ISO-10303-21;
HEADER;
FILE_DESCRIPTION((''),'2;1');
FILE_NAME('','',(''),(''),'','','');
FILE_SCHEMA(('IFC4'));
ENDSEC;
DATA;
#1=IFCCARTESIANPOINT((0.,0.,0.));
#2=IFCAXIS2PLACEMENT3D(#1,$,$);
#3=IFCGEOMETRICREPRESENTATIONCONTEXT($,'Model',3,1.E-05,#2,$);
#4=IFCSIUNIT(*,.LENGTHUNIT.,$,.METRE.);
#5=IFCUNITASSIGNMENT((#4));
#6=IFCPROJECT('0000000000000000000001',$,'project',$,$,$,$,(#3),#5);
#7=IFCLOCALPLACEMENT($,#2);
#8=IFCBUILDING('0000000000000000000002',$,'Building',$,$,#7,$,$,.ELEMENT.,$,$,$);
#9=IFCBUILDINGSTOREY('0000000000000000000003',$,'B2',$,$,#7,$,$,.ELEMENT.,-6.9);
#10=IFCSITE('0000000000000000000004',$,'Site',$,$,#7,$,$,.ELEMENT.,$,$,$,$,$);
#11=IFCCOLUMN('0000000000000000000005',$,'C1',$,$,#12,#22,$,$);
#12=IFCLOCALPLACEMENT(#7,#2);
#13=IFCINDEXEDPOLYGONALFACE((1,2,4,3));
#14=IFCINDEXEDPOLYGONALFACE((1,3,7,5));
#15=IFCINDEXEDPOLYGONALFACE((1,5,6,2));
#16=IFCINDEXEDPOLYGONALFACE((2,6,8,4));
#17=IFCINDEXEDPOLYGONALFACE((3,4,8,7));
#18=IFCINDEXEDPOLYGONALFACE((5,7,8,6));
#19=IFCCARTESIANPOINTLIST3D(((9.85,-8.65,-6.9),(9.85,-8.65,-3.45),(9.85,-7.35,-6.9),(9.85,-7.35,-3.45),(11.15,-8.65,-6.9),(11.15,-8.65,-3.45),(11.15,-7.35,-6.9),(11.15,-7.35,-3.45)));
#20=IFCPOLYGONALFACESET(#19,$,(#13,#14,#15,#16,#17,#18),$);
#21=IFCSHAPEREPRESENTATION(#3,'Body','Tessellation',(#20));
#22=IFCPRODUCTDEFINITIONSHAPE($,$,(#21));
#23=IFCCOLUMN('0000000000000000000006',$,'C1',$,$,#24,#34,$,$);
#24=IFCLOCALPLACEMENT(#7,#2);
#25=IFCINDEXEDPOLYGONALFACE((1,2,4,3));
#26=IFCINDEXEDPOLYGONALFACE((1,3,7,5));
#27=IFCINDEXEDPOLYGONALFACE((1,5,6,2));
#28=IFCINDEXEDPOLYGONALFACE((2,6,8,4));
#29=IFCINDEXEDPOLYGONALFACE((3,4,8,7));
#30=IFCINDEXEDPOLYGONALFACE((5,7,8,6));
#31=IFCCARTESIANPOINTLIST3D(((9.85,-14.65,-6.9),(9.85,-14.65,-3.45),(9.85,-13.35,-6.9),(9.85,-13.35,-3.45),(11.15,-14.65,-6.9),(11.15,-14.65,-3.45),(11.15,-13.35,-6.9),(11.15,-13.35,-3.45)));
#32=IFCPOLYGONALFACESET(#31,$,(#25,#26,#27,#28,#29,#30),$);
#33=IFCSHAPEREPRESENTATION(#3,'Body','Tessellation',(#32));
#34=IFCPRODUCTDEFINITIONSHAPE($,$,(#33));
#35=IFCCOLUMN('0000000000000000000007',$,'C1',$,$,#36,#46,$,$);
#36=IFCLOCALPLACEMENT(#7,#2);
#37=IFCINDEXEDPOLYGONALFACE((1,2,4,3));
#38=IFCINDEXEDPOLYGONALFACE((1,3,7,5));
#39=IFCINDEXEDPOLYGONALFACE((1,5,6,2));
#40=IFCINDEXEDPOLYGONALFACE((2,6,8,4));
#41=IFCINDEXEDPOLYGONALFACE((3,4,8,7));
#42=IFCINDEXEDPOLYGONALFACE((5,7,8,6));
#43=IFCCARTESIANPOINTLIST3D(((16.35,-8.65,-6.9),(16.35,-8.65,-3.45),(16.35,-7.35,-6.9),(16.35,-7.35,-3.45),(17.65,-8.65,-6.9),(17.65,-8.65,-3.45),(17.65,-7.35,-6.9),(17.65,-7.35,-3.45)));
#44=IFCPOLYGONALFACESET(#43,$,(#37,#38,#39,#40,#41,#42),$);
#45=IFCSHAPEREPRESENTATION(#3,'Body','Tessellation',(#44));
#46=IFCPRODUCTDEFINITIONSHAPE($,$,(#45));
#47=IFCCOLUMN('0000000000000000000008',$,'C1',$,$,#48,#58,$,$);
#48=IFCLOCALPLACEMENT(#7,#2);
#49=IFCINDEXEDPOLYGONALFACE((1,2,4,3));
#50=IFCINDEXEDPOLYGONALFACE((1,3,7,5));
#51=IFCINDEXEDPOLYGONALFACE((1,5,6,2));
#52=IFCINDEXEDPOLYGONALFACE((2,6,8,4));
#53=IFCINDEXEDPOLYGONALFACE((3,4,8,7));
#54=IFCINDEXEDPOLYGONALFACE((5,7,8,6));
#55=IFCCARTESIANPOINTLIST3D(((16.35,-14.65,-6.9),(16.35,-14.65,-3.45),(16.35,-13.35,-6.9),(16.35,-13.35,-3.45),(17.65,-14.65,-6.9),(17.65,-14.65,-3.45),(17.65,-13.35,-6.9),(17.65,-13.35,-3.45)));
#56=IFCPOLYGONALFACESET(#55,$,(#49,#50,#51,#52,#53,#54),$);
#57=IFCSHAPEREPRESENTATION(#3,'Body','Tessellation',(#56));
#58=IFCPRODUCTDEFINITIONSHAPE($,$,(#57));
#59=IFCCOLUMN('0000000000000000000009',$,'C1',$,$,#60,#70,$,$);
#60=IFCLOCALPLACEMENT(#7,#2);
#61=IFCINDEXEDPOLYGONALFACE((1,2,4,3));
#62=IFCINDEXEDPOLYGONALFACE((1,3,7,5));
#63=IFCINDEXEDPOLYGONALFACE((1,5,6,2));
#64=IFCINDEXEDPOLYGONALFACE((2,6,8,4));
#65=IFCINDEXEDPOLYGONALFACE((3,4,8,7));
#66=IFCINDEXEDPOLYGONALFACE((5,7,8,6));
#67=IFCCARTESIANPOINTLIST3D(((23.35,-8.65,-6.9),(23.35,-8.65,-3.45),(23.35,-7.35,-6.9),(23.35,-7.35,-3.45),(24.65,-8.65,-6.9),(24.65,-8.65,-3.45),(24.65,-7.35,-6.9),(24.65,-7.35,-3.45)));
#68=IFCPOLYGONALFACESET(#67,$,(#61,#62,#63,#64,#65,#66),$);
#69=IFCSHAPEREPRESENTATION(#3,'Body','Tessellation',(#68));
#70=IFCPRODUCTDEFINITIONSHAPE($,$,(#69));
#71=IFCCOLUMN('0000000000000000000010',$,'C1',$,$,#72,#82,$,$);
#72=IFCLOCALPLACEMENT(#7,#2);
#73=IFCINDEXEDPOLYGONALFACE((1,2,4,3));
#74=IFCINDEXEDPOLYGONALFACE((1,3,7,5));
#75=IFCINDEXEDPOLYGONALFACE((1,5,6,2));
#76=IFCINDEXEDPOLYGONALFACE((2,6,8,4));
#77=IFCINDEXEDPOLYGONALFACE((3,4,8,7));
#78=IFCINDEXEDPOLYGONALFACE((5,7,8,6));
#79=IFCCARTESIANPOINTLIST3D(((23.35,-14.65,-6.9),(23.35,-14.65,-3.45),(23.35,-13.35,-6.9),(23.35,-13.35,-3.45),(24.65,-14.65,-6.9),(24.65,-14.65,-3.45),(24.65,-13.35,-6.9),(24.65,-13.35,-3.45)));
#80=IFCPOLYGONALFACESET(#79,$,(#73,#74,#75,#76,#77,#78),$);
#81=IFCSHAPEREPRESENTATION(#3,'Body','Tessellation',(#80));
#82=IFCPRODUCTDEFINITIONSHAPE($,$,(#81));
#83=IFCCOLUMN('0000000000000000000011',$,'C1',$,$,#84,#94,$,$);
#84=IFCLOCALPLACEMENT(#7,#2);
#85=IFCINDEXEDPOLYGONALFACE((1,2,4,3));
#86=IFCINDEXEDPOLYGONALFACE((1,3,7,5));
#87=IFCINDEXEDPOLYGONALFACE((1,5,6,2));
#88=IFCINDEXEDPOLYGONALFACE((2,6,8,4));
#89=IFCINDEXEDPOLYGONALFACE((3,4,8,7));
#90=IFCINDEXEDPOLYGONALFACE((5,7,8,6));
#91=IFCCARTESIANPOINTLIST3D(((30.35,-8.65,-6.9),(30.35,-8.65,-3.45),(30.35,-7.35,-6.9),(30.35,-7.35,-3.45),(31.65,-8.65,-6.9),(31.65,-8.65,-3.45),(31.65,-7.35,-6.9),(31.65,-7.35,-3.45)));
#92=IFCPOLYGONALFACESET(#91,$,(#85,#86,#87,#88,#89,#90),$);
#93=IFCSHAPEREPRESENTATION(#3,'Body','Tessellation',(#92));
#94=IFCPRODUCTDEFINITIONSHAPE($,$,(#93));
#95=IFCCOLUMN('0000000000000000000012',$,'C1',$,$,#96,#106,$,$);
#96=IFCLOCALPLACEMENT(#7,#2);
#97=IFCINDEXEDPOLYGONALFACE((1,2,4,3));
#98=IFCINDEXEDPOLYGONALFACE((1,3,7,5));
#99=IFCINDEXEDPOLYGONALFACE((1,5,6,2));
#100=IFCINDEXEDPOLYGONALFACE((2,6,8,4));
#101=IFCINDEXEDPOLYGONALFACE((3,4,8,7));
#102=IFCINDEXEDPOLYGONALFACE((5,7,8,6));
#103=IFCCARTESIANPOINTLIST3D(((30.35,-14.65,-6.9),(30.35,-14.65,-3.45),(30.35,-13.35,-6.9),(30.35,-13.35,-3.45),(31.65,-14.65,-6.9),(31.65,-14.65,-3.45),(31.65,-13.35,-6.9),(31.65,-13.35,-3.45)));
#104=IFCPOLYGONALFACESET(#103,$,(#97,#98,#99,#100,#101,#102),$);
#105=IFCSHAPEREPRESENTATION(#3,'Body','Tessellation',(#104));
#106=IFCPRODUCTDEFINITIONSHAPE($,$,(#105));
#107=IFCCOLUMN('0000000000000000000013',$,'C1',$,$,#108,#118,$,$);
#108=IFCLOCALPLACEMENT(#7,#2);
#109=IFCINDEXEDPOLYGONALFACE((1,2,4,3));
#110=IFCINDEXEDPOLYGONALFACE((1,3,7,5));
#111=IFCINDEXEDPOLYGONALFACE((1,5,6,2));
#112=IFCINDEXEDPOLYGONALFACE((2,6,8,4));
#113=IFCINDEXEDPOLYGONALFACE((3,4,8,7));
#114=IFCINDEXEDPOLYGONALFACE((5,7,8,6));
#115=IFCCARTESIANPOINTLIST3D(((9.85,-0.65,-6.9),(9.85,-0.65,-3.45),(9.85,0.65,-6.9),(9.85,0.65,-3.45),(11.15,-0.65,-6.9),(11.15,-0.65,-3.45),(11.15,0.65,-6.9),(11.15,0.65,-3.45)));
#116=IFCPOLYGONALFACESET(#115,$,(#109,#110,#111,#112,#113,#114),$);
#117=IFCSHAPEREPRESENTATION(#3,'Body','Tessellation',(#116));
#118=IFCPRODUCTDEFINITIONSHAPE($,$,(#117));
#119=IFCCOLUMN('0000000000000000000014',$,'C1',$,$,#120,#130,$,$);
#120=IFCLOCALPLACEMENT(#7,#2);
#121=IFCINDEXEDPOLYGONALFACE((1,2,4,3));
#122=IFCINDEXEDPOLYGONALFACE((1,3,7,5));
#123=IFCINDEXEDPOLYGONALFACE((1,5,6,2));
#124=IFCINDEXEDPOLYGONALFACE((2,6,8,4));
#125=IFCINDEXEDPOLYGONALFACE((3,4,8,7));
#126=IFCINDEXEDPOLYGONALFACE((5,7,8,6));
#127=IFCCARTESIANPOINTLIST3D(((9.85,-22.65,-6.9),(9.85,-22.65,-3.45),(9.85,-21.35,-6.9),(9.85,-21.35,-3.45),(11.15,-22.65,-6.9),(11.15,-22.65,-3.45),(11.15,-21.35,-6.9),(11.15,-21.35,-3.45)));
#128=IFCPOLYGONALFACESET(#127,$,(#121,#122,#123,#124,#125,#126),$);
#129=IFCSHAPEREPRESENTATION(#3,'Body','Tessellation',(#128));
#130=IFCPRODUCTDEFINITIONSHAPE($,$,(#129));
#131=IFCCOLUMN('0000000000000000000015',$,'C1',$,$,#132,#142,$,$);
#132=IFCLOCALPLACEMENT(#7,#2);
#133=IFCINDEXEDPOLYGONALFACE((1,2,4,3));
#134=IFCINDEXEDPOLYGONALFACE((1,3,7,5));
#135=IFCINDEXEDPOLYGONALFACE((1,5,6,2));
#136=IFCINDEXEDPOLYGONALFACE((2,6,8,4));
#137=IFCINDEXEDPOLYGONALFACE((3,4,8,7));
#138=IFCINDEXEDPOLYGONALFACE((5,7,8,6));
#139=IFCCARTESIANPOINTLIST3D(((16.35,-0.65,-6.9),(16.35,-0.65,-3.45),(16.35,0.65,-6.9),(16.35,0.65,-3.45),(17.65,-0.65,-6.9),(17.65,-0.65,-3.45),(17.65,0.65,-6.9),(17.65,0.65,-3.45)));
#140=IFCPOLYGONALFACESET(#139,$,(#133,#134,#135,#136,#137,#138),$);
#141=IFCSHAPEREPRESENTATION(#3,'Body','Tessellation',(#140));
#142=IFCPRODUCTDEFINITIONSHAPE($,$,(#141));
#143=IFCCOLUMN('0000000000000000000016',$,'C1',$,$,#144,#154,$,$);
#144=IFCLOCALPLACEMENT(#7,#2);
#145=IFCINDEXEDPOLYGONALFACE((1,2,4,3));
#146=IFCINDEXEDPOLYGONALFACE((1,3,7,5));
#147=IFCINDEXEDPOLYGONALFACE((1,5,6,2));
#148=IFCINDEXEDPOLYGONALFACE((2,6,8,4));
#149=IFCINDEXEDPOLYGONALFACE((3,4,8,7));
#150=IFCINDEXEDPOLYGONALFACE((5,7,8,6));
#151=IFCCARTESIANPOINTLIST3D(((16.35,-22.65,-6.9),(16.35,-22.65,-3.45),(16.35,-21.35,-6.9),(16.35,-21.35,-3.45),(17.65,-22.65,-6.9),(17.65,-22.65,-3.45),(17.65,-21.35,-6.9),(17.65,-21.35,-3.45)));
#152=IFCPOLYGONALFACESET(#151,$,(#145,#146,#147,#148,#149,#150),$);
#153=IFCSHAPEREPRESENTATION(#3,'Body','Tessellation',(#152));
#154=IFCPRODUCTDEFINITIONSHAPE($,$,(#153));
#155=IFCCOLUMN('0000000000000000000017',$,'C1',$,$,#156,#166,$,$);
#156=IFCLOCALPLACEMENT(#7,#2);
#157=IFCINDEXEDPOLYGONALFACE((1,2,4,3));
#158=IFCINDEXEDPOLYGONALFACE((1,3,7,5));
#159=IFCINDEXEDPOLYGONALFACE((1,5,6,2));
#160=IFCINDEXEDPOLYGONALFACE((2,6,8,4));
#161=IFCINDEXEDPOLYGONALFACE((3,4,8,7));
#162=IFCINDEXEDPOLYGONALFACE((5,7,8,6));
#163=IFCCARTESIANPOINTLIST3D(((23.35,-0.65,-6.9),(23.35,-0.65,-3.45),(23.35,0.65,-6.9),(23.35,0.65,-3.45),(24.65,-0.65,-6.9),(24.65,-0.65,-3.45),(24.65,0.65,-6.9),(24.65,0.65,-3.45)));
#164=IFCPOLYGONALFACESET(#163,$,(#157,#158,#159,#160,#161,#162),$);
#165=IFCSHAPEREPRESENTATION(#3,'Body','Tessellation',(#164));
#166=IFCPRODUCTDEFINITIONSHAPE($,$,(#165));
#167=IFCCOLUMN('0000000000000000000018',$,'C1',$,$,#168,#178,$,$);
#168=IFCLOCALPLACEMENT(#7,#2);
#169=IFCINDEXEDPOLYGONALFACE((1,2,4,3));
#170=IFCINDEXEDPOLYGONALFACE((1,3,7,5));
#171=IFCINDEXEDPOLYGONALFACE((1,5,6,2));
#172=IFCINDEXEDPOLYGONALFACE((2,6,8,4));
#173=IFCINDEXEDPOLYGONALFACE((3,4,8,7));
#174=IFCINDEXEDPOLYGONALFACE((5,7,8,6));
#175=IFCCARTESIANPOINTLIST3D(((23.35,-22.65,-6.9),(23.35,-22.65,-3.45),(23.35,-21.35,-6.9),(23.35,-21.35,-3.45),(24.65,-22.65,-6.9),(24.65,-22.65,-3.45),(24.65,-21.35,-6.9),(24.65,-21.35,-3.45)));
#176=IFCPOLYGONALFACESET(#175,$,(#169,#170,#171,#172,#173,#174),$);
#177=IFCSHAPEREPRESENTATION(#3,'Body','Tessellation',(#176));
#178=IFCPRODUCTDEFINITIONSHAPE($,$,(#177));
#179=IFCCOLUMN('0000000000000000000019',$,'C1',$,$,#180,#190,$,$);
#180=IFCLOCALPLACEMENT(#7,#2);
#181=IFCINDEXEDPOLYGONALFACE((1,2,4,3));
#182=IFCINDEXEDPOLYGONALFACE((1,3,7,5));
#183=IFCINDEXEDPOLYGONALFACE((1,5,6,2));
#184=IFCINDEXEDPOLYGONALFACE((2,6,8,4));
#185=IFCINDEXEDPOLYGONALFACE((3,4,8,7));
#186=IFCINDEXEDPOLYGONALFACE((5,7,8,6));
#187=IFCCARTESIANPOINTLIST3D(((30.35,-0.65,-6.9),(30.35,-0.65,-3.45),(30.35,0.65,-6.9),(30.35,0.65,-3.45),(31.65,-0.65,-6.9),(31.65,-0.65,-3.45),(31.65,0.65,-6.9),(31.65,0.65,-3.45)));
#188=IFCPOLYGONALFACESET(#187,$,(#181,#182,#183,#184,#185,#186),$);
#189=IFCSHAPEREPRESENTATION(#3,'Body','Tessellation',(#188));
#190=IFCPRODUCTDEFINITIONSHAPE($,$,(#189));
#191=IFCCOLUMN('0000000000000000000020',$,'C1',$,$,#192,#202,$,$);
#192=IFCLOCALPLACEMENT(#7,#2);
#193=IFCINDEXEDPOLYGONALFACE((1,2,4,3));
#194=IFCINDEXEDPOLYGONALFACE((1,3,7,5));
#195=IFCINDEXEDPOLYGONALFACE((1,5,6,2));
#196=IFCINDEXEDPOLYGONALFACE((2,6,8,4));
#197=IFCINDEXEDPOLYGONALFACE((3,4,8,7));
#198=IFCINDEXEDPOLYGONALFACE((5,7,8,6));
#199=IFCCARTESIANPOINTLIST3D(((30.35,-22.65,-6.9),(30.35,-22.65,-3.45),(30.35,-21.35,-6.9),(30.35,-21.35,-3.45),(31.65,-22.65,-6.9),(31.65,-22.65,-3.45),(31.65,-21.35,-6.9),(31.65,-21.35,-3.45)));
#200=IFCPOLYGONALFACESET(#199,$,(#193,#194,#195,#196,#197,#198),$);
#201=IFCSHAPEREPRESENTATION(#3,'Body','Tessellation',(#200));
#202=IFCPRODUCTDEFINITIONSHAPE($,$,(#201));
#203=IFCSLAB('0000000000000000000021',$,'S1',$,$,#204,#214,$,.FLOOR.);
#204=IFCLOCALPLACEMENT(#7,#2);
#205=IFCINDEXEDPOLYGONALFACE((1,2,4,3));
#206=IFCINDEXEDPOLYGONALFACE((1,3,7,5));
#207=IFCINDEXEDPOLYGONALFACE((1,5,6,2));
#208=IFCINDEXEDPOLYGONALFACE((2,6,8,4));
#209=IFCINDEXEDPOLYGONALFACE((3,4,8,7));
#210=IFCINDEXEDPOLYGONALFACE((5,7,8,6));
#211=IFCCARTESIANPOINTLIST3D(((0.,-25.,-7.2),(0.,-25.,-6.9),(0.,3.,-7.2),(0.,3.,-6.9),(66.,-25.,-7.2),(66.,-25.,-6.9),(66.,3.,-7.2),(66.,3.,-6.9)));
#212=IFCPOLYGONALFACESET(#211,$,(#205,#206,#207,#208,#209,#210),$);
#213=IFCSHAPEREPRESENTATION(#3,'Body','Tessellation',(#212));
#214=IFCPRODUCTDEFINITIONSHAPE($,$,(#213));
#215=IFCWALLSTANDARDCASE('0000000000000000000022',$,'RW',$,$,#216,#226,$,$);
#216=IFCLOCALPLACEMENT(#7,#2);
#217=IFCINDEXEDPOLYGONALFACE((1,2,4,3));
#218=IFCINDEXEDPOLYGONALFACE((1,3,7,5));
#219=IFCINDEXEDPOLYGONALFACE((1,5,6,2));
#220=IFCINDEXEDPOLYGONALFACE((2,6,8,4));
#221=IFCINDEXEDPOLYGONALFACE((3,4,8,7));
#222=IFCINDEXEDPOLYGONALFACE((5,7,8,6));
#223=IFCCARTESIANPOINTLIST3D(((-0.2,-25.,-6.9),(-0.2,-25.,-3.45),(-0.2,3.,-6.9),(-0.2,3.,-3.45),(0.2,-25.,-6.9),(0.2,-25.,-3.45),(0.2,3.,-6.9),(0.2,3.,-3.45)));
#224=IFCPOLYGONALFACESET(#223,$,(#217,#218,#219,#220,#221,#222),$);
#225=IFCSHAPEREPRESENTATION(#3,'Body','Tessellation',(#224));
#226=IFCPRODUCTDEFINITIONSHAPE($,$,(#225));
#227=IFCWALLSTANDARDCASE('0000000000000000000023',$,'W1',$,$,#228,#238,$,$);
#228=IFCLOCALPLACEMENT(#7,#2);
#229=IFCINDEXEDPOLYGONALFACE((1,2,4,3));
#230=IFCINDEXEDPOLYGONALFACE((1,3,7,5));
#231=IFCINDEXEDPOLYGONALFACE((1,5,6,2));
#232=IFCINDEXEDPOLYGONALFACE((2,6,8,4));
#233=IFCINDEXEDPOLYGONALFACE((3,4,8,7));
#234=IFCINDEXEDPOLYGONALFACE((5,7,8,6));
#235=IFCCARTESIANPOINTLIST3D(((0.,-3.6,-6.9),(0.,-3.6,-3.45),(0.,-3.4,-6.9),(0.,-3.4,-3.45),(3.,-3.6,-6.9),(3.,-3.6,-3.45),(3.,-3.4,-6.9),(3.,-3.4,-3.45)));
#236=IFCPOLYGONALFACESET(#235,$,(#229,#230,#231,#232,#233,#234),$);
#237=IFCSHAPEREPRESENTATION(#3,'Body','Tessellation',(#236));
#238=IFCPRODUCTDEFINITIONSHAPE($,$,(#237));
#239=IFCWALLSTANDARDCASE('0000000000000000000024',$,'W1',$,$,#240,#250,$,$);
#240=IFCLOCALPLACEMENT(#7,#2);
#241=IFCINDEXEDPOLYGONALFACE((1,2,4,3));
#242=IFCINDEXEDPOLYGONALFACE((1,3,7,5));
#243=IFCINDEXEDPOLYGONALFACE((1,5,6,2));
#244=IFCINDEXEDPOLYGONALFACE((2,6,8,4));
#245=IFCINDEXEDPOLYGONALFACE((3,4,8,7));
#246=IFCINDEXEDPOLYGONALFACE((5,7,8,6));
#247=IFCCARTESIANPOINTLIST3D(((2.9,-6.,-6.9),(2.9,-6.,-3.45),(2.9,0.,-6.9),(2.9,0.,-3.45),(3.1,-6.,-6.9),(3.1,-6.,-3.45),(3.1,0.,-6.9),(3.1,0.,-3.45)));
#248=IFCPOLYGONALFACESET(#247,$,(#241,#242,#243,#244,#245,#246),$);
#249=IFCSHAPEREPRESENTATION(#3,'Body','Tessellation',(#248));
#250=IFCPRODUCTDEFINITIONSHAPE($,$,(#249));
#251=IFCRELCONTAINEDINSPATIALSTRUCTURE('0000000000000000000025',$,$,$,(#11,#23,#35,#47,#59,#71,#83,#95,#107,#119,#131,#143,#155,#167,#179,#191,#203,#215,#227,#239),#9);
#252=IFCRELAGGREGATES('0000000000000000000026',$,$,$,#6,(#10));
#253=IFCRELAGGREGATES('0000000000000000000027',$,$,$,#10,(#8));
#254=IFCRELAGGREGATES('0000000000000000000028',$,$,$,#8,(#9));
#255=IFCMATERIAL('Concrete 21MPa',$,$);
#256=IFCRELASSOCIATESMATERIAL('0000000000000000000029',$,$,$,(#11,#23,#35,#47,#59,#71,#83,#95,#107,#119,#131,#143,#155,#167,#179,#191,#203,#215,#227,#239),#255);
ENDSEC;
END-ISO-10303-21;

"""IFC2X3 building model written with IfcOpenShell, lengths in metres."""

from ifc_helpers import new_model, si_unit, frame, origin, origin_2d, place, context, project, spatial, rectangle, extrude, material, element, save


model = new_model("IFC2X3")

# Units and contexts
model_context = context("Model", 3, precision=1e-05, world=origin())
ifc_project = project(units=[si_unit("LENGTHUNIT", "METRE")], contexts=[model_context])

# Site, building, storey
placement = place(None, origin())
site = spatial("IfcSite", under=ifc_project, at=placement, Name="Site", CompositionType="ELEMENT")
building = spatial("IfcBuilding", under=site, at=placement, Name="Building", CompositionType="ELEMENT")
storey = spatial("IfcBuildingStorey", under=building, at=placement, Name="B2", CompositionType="ELEMENT", Elevation=-6.9)

# Columns
ifc_material = material(Name="Concrete 21MPa")
for number, where, name in (
    (1, (10.5, -8.0, -6.9), "C1"),
    (2, (10.5, -14.0, -6.9), "C1"),
    (3, (17.0, -8.0, -6.9), "C1"),
    (4, (17.0, -14.0, -6.9), "C1"),
    (5, (24.0, -8.0, -6.9), "C1"),
    (6, (24.0, -14.0, -6.9), "C1"),
    (7, (31.0, -8.0, -6.9), "C1"),
    (8, (31.0, -14.0, -6.9), "C1"),
    (9, (10.5, 0.0, -6.9), "C1"),
    (10, (10.5, -22.0, -6.9), "C1"),
    (11, (17.0, 0.0, -6.9), "C1"),
    (12, (17.0, -22.0, -6.9), "C1"),
    (13, (24.0, 0.0, -6.9), "C1"),
    (14, (24.0, -22.0, -6.9), "C1"),
    (15, (31.0, 0.0, -6.9), "C1"),
    (16, (31.0, -22.0, -6.9), "C1"),
):
    element("IfcColumn", number, at=place(None, frame(where)), inside=storey, material=ifc_material, Name=name, context=model_context, shape_type="SweptSolid", body=[
        extrude(rectangle(XDim=1.3, YDim=1.3, at=origin_2d()), origin(), (0.0, 0.0, 1.0), 3.45),
    ])

# Slab
slab_placement = place(None, frame((33.0, -11.0, -7.2)))
element("IfcSlab", 17, at=slab_placement, inside=storey, material=ifc_material, Name="S1", PredefinedType="FLOOR", context=model_context, shape_type="SweptSolid", body=[
    extrude(rectangle(XDim=66.0, YDim=28.0, at=origin_2d()), origin(), (0.0, 0.0, 1.0), 0.3),
])

# Walls
wall_1_placement = place(None, frame((0.0, -11.0, -6.9)))
element("IfcWallStandardCase", 18, at=wall_1_placement, inside=storey, material=ifc_material, Name="RW", context=model_context, shape_type="SweptSolid", body=[
    extrude(rectangle(XDim=0.4, YDim=28.0, at=origin_2d()), origin(), (0.0, 0.0, 1.0), 3.45),
])
wall_2_placement = place(None, frame((1.5, -3.5, -6.9)))
element("IfcWallStandardCase", 19, at=wall_2_placement, inside=storey, material=ifc_material, Name="W1", context=model_context, shape_type="SweptSolid", body=[
    extrude(rectangle(XDim=3.0, YDim=0.2, at=origin_2d()), origin(), (0.0, 0.0, 1.0), 3.45),
])
wall_3_placement = place(None, frame((3.0, -3.0, -6.9)))
element("IfcWallStandardCase", 20, at=wall_3_placement, inside=storey, material=ifc_material, Name="W1", context=model_context, shape_type="SweptSolid", body=[
    extrude(rectangle(XDim=0.2, YDim=6.0, at=origin_2d()), origin(), (0.0, 0.0, 1.0), 3.45),
])

save(model, "model.ifc")
